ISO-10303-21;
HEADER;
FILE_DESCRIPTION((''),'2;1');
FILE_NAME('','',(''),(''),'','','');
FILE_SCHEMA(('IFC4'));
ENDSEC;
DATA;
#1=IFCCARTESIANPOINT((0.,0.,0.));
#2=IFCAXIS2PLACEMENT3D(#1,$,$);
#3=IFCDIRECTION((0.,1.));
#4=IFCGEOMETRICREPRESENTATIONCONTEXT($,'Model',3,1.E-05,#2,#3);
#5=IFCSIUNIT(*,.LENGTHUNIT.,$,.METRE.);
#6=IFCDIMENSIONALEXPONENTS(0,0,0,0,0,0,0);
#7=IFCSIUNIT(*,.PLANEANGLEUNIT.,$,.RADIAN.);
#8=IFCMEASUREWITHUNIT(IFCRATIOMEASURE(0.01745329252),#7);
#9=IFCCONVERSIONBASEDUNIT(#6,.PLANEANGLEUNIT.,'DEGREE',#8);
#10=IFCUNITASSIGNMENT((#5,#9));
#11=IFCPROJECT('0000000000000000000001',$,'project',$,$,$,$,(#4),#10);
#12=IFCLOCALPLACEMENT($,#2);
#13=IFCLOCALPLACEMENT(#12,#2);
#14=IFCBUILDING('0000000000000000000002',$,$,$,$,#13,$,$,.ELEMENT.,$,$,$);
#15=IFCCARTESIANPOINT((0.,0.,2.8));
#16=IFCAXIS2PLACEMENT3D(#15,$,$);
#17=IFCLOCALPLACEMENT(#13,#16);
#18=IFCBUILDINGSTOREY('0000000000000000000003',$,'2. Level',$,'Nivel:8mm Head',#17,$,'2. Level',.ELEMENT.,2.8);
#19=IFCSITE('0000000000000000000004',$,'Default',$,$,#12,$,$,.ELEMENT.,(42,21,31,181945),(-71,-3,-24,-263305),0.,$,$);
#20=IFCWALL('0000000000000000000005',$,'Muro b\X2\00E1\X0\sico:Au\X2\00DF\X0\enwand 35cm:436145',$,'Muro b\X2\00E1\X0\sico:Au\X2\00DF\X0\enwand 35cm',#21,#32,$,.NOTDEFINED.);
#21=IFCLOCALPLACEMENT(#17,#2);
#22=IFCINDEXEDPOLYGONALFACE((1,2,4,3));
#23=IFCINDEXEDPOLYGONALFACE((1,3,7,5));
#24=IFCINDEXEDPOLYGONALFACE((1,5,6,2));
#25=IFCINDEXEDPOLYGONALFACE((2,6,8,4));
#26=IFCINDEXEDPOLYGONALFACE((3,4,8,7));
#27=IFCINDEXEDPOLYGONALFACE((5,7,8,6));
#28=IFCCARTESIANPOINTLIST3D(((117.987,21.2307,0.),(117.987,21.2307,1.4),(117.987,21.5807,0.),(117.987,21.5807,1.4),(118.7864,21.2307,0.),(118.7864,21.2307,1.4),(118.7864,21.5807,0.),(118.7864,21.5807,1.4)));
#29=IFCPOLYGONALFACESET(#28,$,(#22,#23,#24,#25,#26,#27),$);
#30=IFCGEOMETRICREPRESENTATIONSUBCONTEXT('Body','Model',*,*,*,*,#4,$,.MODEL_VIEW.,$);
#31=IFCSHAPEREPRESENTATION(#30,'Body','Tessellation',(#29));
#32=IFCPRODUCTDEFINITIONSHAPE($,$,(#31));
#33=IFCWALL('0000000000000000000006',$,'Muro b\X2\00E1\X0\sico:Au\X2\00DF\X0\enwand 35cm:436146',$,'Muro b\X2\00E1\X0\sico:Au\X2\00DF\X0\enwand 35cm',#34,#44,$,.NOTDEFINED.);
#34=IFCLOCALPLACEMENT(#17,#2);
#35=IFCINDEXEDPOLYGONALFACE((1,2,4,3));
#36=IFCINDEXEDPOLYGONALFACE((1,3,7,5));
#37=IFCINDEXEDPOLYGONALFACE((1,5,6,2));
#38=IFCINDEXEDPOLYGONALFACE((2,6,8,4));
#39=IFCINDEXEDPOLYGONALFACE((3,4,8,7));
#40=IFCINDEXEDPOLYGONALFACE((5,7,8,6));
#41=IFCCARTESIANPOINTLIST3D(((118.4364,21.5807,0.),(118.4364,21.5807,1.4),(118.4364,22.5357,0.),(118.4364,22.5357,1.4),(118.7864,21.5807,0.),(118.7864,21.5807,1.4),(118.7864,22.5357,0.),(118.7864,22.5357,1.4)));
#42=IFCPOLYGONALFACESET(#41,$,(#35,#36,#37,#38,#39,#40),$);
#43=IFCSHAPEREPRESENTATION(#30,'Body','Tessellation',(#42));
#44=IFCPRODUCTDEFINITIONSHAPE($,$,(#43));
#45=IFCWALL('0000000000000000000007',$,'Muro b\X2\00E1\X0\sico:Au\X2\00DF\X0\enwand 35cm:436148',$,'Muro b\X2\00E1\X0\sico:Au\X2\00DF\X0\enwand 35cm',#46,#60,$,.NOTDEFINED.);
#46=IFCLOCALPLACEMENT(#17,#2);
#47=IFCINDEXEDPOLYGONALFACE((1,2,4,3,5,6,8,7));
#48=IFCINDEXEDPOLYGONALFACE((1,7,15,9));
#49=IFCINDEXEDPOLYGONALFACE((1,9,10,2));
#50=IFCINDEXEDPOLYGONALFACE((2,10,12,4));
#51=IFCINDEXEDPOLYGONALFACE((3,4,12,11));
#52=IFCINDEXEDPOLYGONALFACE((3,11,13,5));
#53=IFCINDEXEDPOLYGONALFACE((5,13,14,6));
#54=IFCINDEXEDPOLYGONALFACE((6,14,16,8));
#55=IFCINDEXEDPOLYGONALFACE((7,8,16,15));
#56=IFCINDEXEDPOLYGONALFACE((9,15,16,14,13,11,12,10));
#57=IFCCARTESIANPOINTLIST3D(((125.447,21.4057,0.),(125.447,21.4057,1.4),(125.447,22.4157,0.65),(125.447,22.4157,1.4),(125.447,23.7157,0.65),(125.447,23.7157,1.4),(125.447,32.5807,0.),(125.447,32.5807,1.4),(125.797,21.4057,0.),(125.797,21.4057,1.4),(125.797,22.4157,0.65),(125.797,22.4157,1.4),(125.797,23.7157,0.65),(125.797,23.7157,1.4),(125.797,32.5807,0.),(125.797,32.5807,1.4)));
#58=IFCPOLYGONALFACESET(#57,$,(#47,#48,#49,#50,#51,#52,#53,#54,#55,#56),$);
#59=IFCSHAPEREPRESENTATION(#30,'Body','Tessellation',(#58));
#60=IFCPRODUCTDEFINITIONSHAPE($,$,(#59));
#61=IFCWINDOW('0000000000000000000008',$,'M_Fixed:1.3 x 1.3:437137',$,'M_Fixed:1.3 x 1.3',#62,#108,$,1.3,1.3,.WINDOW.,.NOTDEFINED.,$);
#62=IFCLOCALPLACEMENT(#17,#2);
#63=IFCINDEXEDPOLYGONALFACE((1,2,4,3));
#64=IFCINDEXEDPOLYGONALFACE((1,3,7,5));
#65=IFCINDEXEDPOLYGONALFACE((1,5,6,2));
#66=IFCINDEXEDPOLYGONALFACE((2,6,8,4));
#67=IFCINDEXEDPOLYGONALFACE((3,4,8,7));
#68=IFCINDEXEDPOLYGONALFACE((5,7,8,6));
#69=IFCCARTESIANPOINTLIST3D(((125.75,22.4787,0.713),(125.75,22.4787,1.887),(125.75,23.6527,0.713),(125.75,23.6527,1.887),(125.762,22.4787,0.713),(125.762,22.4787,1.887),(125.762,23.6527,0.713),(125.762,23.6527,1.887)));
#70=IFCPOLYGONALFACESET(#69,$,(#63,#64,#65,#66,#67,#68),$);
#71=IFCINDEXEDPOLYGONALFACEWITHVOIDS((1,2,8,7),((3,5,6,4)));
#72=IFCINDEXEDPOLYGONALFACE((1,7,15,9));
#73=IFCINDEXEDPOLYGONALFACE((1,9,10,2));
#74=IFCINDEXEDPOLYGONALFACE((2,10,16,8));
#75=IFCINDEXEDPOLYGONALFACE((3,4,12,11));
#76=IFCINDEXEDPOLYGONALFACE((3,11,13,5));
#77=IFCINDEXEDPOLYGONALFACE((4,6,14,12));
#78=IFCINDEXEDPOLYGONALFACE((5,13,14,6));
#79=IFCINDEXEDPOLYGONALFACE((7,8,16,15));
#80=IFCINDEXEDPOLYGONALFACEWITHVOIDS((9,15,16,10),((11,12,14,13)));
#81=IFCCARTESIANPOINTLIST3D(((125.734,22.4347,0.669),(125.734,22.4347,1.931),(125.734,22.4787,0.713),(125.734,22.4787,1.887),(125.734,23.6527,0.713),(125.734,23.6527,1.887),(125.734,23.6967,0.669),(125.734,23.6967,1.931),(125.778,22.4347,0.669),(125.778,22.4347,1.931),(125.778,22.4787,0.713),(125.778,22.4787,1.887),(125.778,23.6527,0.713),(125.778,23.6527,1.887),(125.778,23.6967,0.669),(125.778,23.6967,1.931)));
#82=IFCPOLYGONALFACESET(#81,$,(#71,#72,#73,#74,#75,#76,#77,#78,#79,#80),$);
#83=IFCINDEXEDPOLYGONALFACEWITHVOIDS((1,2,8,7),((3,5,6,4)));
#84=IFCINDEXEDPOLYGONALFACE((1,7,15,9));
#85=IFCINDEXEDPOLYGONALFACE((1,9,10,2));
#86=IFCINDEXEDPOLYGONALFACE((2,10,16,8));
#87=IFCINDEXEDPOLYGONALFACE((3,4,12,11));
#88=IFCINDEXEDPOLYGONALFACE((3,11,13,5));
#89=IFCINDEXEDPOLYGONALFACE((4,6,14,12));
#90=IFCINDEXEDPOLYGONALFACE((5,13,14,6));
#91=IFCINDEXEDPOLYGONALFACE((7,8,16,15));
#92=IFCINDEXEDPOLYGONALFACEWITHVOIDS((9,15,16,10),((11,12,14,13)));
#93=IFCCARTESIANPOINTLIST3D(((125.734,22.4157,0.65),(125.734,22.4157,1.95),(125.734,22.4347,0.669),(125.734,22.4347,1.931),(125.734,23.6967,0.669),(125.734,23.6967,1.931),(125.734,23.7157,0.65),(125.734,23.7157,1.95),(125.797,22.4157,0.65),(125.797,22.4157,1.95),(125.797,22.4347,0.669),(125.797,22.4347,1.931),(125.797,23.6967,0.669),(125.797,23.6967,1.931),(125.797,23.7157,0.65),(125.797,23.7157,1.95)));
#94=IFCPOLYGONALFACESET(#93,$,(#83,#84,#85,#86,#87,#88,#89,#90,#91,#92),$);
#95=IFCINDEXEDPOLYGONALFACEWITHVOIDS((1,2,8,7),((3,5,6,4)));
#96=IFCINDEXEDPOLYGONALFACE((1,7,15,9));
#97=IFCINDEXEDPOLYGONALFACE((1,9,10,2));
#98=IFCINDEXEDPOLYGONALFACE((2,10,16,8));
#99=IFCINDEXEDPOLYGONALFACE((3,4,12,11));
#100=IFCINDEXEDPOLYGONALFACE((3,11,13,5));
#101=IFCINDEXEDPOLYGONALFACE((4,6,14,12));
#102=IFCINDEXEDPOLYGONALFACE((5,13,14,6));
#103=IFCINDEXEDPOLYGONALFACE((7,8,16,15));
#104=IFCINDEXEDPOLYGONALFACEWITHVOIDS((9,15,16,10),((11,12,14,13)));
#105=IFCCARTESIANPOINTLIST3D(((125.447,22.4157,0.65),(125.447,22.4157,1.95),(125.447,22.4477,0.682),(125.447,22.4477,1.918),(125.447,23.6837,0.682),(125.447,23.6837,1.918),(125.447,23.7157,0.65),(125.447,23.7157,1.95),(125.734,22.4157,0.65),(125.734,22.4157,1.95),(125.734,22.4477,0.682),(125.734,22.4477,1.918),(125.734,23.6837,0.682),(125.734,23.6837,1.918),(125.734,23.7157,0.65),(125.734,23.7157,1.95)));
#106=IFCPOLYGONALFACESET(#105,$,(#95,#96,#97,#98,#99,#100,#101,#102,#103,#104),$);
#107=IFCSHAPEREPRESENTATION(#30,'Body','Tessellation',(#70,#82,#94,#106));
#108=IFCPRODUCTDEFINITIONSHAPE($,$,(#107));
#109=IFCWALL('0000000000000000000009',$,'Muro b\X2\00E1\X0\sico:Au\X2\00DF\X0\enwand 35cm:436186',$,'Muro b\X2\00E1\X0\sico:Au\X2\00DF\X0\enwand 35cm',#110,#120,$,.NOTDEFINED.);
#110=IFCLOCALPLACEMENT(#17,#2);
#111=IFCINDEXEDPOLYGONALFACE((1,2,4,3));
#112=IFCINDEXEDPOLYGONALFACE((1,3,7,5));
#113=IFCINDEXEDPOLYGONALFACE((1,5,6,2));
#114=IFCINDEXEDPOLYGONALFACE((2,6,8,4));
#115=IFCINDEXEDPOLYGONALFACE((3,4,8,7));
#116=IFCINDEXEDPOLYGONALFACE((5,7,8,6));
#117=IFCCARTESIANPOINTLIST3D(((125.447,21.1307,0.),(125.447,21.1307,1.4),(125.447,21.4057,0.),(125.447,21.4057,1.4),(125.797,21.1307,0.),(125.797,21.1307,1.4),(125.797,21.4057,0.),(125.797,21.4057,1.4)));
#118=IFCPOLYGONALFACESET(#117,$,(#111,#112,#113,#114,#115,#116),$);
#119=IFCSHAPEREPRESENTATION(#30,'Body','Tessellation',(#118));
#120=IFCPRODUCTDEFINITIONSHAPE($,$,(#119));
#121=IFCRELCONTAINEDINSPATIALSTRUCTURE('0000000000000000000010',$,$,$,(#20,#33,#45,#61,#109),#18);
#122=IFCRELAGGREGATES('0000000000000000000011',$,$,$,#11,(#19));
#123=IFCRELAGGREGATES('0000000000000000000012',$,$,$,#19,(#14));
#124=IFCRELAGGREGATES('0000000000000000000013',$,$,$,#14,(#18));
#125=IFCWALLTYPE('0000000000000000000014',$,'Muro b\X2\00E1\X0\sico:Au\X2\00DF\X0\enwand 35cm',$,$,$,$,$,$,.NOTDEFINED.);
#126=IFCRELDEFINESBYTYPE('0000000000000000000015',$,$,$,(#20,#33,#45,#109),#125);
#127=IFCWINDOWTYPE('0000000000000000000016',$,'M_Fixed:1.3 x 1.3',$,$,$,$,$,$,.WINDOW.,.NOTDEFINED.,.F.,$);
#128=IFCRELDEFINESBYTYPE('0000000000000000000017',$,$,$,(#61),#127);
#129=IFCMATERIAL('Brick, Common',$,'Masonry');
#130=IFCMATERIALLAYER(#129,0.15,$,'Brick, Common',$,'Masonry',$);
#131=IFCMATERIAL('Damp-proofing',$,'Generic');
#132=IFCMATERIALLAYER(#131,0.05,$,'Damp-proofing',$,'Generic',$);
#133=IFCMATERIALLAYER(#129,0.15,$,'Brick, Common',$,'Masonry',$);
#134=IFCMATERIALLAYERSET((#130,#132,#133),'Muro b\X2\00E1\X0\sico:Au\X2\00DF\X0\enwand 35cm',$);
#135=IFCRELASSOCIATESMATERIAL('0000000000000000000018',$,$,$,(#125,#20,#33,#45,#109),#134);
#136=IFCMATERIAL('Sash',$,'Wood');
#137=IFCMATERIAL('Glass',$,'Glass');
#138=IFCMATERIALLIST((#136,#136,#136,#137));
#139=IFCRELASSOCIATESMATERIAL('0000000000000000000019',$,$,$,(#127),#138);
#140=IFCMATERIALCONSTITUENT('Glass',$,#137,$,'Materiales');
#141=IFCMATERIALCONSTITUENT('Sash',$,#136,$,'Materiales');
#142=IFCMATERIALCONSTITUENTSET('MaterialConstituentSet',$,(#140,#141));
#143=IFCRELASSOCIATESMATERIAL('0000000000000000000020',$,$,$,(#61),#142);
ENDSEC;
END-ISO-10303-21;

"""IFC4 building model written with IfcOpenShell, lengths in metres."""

from ifc_helpers import new_model, entity, si_unit, converted_unit, direction, frame, frame_2d, origin, origin_2d_with_axis, place, context, subcontext, project, spatial, polyline, rectangle, outline, extrude, clip, halfspace, source, transform, mapped, material, material_list, layer, layer_set, layer_usage, constituent, constituent_set, type_object, type_shapes, element, fill, save


model = new_model("IFC4")

# Units and contexts
model_context = context("Model", 3, precision=1e-05, world=origin(), true_north=direction((0.0, 1.0)))
body_context = subcontext(model_context, "Body", "Model", "MODEL_VIEW")
ifc_project = project(units=[si_unit("LENGTHUNIT", "METRE"), converted_unit("PLANEANGLEUNIT", "DEGREE", entity("IfcRatioMeasure", 0.01745329252), si_unit("PLANEANGLEUNIT", "RADIAN"), dimensions=[0, 0, 0, 0, 0, 0, 0])], contexts=[model_context])

# Site, building, storey
site_placement = place(None, origin())
site = spatial("IfcSite", under=ifc_project, at=site_placement, Name="Default", CompositionType="ELEMENT", RefLatitude=(42, 21, 31, 181945), RefLongitude=(-71, -3, -24, -263305), RefElevation=0.0)
building_placement = place(site_placement, origin())
building = spatial("IfcBuilding", under=site, at=building_placement, CompositionType="ELEMENT")
storey_placement = place(building_placement, frame((0.0, 0.0, 2.8)))
storey = spatial("IfcBuildingStorey", under=building, at=storey_placement, Name="2. Level", ObjectType="Nivel:8mm Head", LongName="2. Level", CompositionType="ELEMENT", Elevation=2.8)

# Walls
ifc_material_1 = material(Name="Brick, Common", Category="Masonry")
ifc_layer_1 = layer(ifc_material_1, 0.15, Name="Brick, Common", Category="Masonry")
ifc_material_2 = material(Name="Damp-proofing", Category="Generic")
ifc_layer_2 = layer(ifc_material_2, 0.05, Name="Damp-proofing", Category="Generic")
ifc_layer_3 = layer(ifc_material_1, 0.15, Name="Brick, Common", Category="Masonry")
ifc_layer_set_1 = layer_set([ifc_layer_1, ifc_layer_2, ifc_layer_3], Name="Muro básico:Außenwand 35cm")
ifc_layer_usage_1 = layer_usage(ifc_layer_set_1, "AXIS2", "NEGATIVE", 0.175)
wall_type_1 = type_object("IfcWallType", Name="Muro básico:Außenwand 35cm", PredefinedType="NOTDEFINED", material=ifc_layer_set_1)
wall_1_placement = place(storey_placement, frame((117.987, 21.4057, 0.0)))
element("IfcWall", 1, at=wall_1_placement, inside=storey, type_object=wall_type_1, material=ifc_layer_usage_1, Name="Muro básico:Außenwand 35cm:436145", ObjectType="Muro básico:Außenwand 35cm", PredefinedType="NOTDEFINED", context=body_context, shape_type="Clipping", body=[
    clip(extrude(rectangle(XDim=0.7994, YDim=0.35, at=frame_2d((0.3997, 0.0), x_axis=(-1.0, 0.0))), origin(), (0.0, 0.0, 1.0), 1.4), halfspace(origin(), True)),
])
ifc_layer_usage_2 = layer_usage(ifc_layer_set_1, "AXIS2", "NEGATIVE", 0.175)
wall_2_placement = place(storey_placement, frame((118.6114, 21.5807, 0.0), z_axis=(0.0, 0.0, 1.0), x_axis=(0.0, 1.0, 0.0)))
element("IfcWall", 2, at=wall_2_placement, inside=storey, type_object=wall_type_1, material=ifc_layer_usage_2, Name="Muro básico:Außenwand 35cm:436146", ObjectType="Muro básico:Außenwand 35cm", PredefinedType="NOTDEFINED", context=body_context, shape_type="Clipping", body=[
    clip(extrude(rectangle(XDim=0.955, YDim=0.35, at=frame_2d((0.4775, 0.0), x_axis=(-1.0, 0.0))), origin(), (0.0, 0.0, 1.0), 1.4), halfspace(origin(), True)),
])

# Wall, opening, window
ifc_layer_usage_3 = layer_usage(ifc_layer_set_1, "AXIS2", "NEGATIVE", 0.175)
wall_3_placement = place(storey_placement, frame((125.622, 21.4057, 0.0), z_axis=(0.0, 0.0, 1.0), x_axis=(0.0, 1.0, 0.0)))
wall_3 = element("IfcWall", 3, at=wall_3_placement, inside=storey, type_object=wall_type_1, material=ifc_layer_usage_3, Name="Muro básico:Außenwand 35cm:436148", ObjectType="Muro básico:Außenwand 35cm", PredefinedType="NOTDEFINED", context=body_context, shape_type="Clipping", body=[
    clip(extrude(rectangle(XDim=11.175, YDim=0.35, at=frame_2d((5.5875, 0.0), x_axis=(-1.0, 0.0))), origin(), (0.0, 0.0, 1.0), 1.4), halfspace(origin(), True)),
])
opening_1_placement = place(wall_3_placement, frame((2.31, 0.175, 0.65)))
opening_1 = element("IfcOpeningElement", 4, at=opening_1_placement, cuts=wall_3, ObjectType="Opening", PredefinedType="OPENING", context=body_context, shape_type="SweptSolid", body=[
    extrude(rectangle(XDim=1.3, YDim=1.3, at=frame_2d((0.65, 0.65), x_axis=(1.0, 0.0))), frame((0.0, 0.0, 0.0), z_axis=(0.0, -1.0, 0.0), x_axis=(0.0, 0.0, 1.0)), (0.0, 0.0, 1.0), 0.35),
])
ifc_material_3 = material(Name="Glass", Category="Glass")
ifc_constituent_1 = constituent(ifc_material_3, Name="Glass", Category="Materiales")
ifc_material_4 = material(Name="Sash", Category="Wood")
ifc_constituent_2 = constituent(ifc_material_4, Name="Sash", Category="Materiales")
ifc_constituent_set_1 = constituent_set(constituents=[ifc_constituent_1, ifc_constituent_2], Name="MaterialConstituentSet")
ifc_material_list_1 = material_list([ifc_material_4, ifc_material_4, ifc_material_4, ifc_material_3])
window_type = type_object("IfcWindowType", Name="M_Fixed:1.3 x 1.3", ParameterTakesPrecedence=False, PartitioningType="NOTDEFINED", PredefinedType="WINDOW", material=ifc_material_list_1)
shared_shape_1 = source(origin(), body_context, "Body", "SweptSolid", [
    extrude(rectangle(XDim=0.012, YDim=1.174, at=origin_2d_with_axis()), frame((0.65, 0.309, 0.063), z_axis=(0.0, 0.0, 1.0), x_axis=(0.0, -1.0, 0.0)), (0.0, 0.0, 1.0), 1.174),
    extrude(outline(polyline([(-0.631, -0.631), (0.631, -0.631), (0.631, 0.631), (-0.631, 0.631), (-0.631, -0.631)]), holes=[polyline([(-0.587, -0.587), (-0.587, 0.587), (0.587, 0.587), (0.587, -0.587), (-0.587, -0.587)])]), frame((0.65, 0.287, 0.65), z_axis=(0.0, 1.0, 0.0), x_axis=(1.0, 0.0, 0.0)), (0.0, 0.0, 1.0), 0.044),
    extrude(outline(polyline([(-0.65, -0.65), (0.65, -0.65), (0.65, 0.65), (-0.65, 0.65), (-0.65, -0.65)]), holes=[polyline([(-0.631, -0.631), (-0.631, 0.631), (0.631, 0.631), (0.631, -0.631), (-0.631, -0.631)])]), frame((0.65, 0.287, 0.65), z_axis=(0.0, 1.0, 0.0), x_axis=(1.0, 0.0, 0.0)), (0.0, 0.0, 1.0), 0.063),
    extrude(outline(polyline([(-0.65, -0.65), (0.65, -0.65), (0.65, 0.65), (-0.65, 0.65), (-0.65, -0.65)]), holes=[polyline([(-0.618, -0.618), (-0.618, 0.618), (0.618, 0.618), (0.618, -0.618), (-0.618, -0.618)])]), frame((0.65, 0.0, 0.65), z_axis=(0.0, 1.0, 0.0), x_axis=(1.0, 0.0, 0.0)), (0.0, 0.0, 1.0), 0.287),
])
type_shapes(window_type, [shared_shape_1])
window_placement = place(opening_1_placement, frame((0.0, 0.0, 0.0), z_axis=(0.0, 0.0, 1.0), x_axis=(-1.0, 0.0, 0.0)))
window = element("IfcWindow", 5, at=window_placement, inside=storey, type_object=window_type, material=ifc_constituent_set_1, Name="M_Fixed:1.3 x 1.3:437137", ObjectType="M_Fixed:1.3 x 1.3", OverallHeight=1.3, OverallWidth=1.3, PartitioningType="NOTDEFINED", PredefinedType="WINDOW", context=body_context, shape_type="MappedRepresentation", body=[
    mapped(shared_shape_1, transform((0.0, 0.0, 0.0), scale=1.0)),
])
fill(opening_1, window)

# Wall
ifc_layer_usage_4 = layer_usage(ifc_layer_set_1, "AXIS2", "NEGATIVE", 0.175)
wall_4_placement = place(storey_placement, frame((125.622, 21.4057, 0.0), z_axis=(0.0, 0.0, 1.0), x_axis=(0.0, -1.0, 0.0)))
element("IfcWall", 6, at=wall_4_placement, inside=storey, type_object=wall_type_1, material=ifc_layer_usage_4, Name="Muro básico:Außenwand 35cm:436186", ObjectType="Muro básico:Außenwand 35cm", PredefinedType="NOTDEFINED", context=body_context, shape_type="Clipping", body=[
    clip(extrude(rectangle(XDim=0.275, YDim=0.35, at=frame_2d((0.1375, 0.0), x_axis=(-1.0, 0.0))), origin(), (0.0, 0.0, 1.0), 1.4), halfspace(origin(), True)),
])

save(model, "model.ifc")
